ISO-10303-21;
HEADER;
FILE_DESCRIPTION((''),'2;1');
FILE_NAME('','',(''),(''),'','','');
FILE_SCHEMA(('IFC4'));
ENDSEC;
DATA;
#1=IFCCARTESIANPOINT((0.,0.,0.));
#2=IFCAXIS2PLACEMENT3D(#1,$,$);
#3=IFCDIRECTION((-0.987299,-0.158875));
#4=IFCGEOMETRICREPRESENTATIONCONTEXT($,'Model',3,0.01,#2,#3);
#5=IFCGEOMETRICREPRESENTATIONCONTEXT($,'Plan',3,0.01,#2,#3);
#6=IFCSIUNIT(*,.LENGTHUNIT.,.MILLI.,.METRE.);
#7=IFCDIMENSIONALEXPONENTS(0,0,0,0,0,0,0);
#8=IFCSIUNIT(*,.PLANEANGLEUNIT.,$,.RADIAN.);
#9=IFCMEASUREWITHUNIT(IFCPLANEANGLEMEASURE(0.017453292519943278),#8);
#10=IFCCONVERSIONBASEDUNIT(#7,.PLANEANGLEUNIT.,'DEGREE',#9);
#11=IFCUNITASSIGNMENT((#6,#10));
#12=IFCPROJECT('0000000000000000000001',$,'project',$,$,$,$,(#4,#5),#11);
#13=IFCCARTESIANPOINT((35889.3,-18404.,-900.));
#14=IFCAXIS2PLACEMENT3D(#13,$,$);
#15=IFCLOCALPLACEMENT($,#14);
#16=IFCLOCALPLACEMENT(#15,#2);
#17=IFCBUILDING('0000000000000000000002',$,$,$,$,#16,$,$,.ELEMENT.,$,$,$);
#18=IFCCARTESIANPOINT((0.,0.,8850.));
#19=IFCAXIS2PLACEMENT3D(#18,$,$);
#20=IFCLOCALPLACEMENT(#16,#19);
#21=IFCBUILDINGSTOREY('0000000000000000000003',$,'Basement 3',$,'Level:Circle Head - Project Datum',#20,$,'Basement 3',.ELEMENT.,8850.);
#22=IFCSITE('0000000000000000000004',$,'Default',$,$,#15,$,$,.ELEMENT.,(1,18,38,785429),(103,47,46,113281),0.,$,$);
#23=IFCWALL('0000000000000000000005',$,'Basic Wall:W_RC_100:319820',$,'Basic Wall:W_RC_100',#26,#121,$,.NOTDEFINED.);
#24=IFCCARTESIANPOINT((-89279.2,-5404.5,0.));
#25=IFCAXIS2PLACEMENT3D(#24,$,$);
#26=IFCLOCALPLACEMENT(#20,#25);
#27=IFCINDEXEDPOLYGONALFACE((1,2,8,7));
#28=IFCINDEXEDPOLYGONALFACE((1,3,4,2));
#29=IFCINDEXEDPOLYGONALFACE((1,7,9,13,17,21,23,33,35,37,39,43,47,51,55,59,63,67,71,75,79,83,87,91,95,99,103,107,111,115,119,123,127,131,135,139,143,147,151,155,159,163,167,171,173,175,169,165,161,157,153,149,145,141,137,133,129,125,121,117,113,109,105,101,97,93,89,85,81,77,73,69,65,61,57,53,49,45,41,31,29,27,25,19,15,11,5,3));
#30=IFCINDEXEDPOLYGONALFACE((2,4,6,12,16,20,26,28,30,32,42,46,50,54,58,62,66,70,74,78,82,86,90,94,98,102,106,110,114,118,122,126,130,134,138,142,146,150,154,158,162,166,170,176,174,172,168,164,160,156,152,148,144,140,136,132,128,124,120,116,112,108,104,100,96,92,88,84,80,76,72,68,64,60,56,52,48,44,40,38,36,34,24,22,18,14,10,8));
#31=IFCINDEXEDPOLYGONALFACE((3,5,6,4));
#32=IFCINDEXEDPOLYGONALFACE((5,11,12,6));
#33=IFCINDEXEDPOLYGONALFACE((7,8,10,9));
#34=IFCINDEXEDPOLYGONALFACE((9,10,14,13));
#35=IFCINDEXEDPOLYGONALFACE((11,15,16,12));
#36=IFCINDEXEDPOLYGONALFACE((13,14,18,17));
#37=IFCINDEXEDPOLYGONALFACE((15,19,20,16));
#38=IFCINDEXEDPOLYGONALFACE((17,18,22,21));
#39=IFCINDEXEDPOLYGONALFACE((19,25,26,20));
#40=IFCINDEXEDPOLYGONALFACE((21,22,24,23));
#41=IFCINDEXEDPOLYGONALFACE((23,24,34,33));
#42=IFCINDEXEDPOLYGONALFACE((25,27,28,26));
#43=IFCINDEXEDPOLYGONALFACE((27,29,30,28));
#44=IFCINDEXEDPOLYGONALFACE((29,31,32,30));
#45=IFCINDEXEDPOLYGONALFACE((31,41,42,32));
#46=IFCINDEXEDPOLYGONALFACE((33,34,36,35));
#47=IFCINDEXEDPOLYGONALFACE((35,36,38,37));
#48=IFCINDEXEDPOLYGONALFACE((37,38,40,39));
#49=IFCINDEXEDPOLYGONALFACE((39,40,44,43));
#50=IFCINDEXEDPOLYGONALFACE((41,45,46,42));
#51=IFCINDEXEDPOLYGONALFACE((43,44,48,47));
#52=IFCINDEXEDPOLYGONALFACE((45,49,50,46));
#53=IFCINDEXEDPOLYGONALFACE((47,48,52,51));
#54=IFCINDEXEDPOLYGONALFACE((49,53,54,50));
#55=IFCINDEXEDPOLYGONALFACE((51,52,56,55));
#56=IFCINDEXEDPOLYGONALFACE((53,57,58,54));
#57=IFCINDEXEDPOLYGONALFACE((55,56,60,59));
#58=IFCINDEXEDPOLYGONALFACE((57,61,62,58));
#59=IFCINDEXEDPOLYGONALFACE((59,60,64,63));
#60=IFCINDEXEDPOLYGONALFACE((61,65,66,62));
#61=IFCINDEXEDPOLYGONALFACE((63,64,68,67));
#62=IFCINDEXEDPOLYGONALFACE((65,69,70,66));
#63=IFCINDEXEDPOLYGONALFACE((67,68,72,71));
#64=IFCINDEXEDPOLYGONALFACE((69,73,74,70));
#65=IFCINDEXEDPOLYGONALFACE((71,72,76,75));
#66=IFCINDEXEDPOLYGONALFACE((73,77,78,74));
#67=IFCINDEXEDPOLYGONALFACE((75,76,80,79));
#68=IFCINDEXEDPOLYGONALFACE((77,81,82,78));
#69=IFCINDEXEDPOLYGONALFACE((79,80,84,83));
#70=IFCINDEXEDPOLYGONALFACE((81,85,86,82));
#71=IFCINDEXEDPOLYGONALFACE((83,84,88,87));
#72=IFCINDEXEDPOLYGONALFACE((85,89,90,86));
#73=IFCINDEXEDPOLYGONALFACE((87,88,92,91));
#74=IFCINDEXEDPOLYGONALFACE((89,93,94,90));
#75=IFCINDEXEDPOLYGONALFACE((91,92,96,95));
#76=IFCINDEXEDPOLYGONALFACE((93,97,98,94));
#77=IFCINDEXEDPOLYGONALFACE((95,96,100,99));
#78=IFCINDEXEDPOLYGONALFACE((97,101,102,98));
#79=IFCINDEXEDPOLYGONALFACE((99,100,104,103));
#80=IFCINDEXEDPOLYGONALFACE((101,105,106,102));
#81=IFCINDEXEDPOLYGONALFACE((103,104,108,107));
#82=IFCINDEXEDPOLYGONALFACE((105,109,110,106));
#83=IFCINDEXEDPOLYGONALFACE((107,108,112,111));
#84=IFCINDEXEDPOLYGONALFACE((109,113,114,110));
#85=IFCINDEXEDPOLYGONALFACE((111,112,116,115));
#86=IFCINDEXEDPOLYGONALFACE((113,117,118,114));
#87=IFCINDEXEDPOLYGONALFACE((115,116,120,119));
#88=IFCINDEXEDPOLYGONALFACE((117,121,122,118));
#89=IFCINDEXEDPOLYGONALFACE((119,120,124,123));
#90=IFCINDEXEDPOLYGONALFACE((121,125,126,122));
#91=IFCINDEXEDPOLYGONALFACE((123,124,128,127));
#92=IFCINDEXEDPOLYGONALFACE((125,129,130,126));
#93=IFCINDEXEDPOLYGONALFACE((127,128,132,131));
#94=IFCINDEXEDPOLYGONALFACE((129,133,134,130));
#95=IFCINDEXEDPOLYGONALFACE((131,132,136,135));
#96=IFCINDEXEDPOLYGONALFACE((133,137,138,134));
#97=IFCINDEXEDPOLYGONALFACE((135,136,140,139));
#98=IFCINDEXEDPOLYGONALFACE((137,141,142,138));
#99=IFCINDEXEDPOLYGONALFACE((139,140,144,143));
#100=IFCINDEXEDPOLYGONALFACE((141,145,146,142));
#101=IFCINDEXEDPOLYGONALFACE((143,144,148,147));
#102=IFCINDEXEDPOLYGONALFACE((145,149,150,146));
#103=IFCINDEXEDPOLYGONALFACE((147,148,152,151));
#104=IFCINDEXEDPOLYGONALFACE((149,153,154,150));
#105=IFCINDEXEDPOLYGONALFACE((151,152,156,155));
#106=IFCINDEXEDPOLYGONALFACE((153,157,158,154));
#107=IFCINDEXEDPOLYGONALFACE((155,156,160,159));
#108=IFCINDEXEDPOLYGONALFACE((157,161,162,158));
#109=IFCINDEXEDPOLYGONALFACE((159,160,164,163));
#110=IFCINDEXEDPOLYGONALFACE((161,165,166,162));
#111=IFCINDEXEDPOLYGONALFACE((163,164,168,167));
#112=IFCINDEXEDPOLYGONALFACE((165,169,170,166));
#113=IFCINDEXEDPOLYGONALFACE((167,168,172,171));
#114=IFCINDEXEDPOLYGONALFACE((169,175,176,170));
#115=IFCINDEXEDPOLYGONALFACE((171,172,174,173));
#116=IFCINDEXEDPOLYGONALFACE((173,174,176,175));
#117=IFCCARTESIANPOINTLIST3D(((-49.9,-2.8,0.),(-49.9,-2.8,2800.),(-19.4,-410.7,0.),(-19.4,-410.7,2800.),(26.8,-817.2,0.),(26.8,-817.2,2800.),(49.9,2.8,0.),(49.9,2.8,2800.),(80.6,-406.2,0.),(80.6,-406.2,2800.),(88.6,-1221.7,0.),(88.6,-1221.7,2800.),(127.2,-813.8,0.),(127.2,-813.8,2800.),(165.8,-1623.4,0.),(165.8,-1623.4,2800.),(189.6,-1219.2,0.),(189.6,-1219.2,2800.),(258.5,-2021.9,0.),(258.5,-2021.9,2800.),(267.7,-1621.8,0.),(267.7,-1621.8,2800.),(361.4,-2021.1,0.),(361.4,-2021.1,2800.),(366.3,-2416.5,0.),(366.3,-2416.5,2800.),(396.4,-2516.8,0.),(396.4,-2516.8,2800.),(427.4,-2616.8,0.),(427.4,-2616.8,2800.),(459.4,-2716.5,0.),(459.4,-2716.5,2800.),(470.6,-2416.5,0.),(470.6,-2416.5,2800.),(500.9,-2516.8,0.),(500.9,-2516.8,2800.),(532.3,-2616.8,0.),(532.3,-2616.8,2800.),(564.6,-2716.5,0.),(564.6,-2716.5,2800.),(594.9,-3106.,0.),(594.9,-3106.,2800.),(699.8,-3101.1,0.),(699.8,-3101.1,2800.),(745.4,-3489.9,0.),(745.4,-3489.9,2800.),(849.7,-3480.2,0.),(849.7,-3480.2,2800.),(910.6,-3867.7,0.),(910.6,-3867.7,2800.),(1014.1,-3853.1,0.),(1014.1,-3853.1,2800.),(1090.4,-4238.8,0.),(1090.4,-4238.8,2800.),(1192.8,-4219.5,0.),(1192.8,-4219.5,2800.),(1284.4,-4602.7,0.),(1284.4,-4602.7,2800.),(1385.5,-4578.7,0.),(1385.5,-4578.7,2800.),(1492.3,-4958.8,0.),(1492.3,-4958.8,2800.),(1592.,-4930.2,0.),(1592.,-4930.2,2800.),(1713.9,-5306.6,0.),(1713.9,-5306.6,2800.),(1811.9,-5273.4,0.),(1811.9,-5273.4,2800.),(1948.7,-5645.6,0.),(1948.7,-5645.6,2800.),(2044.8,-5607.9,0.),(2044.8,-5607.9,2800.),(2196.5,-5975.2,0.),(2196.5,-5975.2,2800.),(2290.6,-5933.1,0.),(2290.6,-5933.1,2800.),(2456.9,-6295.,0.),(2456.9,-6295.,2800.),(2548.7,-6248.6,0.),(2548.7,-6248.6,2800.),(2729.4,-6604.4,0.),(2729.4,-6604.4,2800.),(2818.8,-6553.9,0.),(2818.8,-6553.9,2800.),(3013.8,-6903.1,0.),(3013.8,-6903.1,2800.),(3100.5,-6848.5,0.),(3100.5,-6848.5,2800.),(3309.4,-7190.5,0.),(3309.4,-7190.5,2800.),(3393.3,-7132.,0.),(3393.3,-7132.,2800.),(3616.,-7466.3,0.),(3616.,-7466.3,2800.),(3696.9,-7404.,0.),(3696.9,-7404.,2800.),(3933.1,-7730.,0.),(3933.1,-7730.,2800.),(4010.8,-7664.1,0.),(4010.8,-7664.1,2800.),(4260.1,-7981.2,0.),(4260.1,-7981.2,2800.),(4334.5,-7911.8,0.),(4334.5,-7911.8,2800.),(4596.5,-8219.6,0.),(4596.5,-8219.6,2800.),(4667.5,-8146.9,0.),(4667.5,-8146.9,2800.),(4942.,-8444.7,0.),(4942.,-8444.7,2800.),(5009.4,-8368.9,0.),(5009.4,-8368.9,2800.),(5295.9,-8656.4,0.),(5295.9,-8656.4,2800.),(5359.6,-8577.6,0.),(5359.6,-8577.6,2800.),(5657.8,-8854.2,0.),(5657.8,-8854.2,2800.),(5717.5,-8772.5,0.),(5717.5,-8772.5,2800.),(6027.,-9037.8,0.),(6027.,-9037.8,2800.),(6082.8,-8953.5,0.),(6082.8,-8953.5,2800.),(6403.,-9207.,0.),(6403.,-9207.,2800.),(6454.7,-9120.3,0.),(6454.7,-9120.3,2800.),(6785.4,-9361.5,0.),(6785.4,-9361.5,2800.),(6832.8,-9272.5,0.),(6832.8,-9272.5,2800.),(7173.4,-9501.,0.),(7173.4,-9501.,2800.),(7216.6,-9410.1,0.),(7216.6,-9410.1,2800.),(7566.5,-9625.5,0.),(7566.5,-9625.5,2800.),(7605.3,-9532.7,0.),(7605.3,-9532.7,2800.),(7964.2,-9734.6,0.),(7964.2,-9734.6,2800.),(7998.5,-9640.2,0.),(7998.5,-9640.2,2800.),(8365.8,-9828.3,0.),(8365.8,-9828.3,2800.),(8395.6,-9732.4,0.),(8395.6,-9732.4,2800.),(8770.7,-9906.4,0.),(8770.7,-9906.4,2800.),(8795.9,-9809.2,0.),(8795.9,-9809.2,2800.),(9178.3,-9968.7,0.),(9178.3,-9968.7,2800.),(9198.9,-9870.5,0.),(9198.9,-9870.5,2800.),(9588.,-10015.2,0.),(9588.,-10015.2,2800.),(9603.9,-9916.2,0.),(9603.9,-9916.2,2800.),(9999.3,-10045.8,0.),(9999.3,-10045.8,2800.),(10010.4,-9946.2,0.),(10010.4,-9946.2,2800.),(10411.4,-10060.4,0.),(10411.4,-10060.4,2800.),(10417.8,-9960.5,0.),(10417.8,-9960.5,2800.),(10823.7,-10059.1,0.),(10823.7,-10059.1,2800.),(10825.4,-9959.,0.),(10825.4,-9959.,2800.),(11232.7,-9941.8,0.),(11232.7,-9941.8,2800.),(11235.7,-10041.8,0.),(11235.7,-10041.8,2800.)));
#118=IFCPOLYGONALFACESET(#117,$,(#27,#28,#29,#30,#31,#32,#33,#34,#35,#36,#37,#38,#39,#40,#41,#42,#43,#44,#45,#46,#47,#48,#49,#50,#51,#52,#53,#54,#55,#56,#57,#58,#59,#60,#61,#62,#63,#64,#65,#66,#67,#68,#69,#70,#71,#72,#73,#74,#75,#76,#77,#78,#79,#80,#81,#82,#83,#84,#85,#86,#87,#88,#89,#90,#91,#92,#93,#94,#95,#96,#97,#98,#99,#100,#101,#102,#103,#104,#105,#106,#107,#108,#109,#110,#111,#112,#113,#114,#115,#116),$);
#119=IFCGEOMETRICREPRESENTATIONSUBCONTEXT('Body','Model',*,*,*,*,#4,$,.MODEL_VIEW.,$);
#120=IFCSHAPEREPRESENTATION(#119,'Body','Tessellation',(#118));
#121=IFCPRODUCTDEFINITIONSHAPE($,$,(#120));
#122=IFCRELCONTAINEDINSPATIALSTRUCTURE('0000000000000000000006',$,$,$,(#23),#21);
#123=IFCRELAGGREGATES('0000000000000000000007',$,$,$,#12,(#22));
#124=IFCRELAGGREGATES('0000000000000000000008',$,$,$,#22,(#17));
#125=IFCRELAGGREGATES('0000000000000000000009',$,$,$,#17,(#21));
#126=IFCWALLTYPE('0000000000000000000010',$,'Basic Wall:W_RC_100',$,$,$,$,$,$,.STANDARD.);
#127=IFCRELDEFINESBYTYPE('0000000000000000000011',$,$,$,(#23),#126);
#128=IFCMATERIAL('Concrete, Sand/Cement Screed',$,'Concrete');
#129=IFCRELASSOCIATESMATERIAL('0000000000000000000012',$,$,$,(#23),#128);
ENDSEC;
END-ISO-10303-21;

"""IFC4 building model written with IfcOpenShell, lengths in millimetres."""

from ifc_helpers import new_model, entity, si_unit, converted_unit, direction, frame, origin, place, context, subcontext, project, spatial, line, arc, indexed_curve, outline, extrude, material, type_object, element, save


model = new_model("IFC4")

# Units and contexts
model_context = context("Model", 3, precision=0.01, world=origin(), true_north=direction((-0.987299, -0.158875)))
plan_context = context("Plan", 3, precision=0.01, world=origin(), true_north=direction((-0.987299, -0.158875)))
body_context = subcontext(model_context, "Body", "Model", "MODEL_VIEW")
ifc_project = project(units=[si_unit("LENGTHUNIT", "METRE", prefix="MILLI"), converted_unit("PLANEANGLEUNIT", "DEGREE", entity("IfcPlaneAngleMeasure", 0.017453292519943278), si_unit("PLANEANGLEUNIT", "RADIAN"), dimensions=[0, 0, 0, 0, 0, 0, 0])], contexts=[model_context, plan_context])

# Site, building, storey
site_placement = place(None, frame((35889.3, -18404.0, -900.0)))
site = spatial("IfcSite", under=ifc_project, at=site_placement, Name="Default", CompositionType="ELEMENT", RefLatitude=(1, 18, 38, 785429), RefLongitude=(103, 47, 46, 113281), RefElevation=0.0)
building_placement = place(site_placement, origin())
building = spatial("IfcBuilding", under=site, at=building_placement, CompositionType="ELEMENT")
storey_placement = place(building_placement, frame((0.0, 0.0, 8850.0)))
storey = spatial("IfcBuildingStorey", under=building, at=storey_placement, Name="Basement 3", ObjectType="Level:Circle Head - Project Datum", LongName="Basement 3", CompositionType="ELEMENT", Elevation=8850.0)

# Wall
ifc_material_1 = material(Name="Concrete, Sand/Cement Screed", Category="Concrete")
wall_type_1 = type_object("IfcWallType", Name="Basic Wall:W_RC_100", PredefinedType="STANDARD")
wall_1_placement = place(storey_placement, frame((-89279.2, -5404.5, 0.0)))
element("IfcWall", 1, at=wall_1_placement, inside=storey, type_object=wall_type_1, material=ifc_material_1, Name="Basic Wall:W_RC_100:319820", ObjectType="Basic Wall:W_RC_100", PredefinedType="NOTDEFINED", context=body_context, shape_type="SweptSolid", body=[
    extrude(outline(indexed_curve([(11232.7, -9941.8), (4667.5, -8146.9), (564.6, -2716.5), (516.5, -2566.9), (470.6, -2416.5), (189.6, -1219.2), (49.9, 2.8), (-49.9, -2.8), (88.6, -1221.7), (366.3, -2416.5), (411.7, -2566.9), (459.4, -2716.5), (4596.5, -8219.6), (11235.7, -10041.8)], segments=[arc(1, 2, 3), arc(3, 4, 5), arc(5, 6, 7), line(7, 8), arc(8, 9, 10), arc(10, 11, 12), arc(12, 13, 14), line(14, 1)], self_intersect=False)), origin(), (0.0, 0.0, 1.0), 2800.0),
])

save(model, "model.ifc")
